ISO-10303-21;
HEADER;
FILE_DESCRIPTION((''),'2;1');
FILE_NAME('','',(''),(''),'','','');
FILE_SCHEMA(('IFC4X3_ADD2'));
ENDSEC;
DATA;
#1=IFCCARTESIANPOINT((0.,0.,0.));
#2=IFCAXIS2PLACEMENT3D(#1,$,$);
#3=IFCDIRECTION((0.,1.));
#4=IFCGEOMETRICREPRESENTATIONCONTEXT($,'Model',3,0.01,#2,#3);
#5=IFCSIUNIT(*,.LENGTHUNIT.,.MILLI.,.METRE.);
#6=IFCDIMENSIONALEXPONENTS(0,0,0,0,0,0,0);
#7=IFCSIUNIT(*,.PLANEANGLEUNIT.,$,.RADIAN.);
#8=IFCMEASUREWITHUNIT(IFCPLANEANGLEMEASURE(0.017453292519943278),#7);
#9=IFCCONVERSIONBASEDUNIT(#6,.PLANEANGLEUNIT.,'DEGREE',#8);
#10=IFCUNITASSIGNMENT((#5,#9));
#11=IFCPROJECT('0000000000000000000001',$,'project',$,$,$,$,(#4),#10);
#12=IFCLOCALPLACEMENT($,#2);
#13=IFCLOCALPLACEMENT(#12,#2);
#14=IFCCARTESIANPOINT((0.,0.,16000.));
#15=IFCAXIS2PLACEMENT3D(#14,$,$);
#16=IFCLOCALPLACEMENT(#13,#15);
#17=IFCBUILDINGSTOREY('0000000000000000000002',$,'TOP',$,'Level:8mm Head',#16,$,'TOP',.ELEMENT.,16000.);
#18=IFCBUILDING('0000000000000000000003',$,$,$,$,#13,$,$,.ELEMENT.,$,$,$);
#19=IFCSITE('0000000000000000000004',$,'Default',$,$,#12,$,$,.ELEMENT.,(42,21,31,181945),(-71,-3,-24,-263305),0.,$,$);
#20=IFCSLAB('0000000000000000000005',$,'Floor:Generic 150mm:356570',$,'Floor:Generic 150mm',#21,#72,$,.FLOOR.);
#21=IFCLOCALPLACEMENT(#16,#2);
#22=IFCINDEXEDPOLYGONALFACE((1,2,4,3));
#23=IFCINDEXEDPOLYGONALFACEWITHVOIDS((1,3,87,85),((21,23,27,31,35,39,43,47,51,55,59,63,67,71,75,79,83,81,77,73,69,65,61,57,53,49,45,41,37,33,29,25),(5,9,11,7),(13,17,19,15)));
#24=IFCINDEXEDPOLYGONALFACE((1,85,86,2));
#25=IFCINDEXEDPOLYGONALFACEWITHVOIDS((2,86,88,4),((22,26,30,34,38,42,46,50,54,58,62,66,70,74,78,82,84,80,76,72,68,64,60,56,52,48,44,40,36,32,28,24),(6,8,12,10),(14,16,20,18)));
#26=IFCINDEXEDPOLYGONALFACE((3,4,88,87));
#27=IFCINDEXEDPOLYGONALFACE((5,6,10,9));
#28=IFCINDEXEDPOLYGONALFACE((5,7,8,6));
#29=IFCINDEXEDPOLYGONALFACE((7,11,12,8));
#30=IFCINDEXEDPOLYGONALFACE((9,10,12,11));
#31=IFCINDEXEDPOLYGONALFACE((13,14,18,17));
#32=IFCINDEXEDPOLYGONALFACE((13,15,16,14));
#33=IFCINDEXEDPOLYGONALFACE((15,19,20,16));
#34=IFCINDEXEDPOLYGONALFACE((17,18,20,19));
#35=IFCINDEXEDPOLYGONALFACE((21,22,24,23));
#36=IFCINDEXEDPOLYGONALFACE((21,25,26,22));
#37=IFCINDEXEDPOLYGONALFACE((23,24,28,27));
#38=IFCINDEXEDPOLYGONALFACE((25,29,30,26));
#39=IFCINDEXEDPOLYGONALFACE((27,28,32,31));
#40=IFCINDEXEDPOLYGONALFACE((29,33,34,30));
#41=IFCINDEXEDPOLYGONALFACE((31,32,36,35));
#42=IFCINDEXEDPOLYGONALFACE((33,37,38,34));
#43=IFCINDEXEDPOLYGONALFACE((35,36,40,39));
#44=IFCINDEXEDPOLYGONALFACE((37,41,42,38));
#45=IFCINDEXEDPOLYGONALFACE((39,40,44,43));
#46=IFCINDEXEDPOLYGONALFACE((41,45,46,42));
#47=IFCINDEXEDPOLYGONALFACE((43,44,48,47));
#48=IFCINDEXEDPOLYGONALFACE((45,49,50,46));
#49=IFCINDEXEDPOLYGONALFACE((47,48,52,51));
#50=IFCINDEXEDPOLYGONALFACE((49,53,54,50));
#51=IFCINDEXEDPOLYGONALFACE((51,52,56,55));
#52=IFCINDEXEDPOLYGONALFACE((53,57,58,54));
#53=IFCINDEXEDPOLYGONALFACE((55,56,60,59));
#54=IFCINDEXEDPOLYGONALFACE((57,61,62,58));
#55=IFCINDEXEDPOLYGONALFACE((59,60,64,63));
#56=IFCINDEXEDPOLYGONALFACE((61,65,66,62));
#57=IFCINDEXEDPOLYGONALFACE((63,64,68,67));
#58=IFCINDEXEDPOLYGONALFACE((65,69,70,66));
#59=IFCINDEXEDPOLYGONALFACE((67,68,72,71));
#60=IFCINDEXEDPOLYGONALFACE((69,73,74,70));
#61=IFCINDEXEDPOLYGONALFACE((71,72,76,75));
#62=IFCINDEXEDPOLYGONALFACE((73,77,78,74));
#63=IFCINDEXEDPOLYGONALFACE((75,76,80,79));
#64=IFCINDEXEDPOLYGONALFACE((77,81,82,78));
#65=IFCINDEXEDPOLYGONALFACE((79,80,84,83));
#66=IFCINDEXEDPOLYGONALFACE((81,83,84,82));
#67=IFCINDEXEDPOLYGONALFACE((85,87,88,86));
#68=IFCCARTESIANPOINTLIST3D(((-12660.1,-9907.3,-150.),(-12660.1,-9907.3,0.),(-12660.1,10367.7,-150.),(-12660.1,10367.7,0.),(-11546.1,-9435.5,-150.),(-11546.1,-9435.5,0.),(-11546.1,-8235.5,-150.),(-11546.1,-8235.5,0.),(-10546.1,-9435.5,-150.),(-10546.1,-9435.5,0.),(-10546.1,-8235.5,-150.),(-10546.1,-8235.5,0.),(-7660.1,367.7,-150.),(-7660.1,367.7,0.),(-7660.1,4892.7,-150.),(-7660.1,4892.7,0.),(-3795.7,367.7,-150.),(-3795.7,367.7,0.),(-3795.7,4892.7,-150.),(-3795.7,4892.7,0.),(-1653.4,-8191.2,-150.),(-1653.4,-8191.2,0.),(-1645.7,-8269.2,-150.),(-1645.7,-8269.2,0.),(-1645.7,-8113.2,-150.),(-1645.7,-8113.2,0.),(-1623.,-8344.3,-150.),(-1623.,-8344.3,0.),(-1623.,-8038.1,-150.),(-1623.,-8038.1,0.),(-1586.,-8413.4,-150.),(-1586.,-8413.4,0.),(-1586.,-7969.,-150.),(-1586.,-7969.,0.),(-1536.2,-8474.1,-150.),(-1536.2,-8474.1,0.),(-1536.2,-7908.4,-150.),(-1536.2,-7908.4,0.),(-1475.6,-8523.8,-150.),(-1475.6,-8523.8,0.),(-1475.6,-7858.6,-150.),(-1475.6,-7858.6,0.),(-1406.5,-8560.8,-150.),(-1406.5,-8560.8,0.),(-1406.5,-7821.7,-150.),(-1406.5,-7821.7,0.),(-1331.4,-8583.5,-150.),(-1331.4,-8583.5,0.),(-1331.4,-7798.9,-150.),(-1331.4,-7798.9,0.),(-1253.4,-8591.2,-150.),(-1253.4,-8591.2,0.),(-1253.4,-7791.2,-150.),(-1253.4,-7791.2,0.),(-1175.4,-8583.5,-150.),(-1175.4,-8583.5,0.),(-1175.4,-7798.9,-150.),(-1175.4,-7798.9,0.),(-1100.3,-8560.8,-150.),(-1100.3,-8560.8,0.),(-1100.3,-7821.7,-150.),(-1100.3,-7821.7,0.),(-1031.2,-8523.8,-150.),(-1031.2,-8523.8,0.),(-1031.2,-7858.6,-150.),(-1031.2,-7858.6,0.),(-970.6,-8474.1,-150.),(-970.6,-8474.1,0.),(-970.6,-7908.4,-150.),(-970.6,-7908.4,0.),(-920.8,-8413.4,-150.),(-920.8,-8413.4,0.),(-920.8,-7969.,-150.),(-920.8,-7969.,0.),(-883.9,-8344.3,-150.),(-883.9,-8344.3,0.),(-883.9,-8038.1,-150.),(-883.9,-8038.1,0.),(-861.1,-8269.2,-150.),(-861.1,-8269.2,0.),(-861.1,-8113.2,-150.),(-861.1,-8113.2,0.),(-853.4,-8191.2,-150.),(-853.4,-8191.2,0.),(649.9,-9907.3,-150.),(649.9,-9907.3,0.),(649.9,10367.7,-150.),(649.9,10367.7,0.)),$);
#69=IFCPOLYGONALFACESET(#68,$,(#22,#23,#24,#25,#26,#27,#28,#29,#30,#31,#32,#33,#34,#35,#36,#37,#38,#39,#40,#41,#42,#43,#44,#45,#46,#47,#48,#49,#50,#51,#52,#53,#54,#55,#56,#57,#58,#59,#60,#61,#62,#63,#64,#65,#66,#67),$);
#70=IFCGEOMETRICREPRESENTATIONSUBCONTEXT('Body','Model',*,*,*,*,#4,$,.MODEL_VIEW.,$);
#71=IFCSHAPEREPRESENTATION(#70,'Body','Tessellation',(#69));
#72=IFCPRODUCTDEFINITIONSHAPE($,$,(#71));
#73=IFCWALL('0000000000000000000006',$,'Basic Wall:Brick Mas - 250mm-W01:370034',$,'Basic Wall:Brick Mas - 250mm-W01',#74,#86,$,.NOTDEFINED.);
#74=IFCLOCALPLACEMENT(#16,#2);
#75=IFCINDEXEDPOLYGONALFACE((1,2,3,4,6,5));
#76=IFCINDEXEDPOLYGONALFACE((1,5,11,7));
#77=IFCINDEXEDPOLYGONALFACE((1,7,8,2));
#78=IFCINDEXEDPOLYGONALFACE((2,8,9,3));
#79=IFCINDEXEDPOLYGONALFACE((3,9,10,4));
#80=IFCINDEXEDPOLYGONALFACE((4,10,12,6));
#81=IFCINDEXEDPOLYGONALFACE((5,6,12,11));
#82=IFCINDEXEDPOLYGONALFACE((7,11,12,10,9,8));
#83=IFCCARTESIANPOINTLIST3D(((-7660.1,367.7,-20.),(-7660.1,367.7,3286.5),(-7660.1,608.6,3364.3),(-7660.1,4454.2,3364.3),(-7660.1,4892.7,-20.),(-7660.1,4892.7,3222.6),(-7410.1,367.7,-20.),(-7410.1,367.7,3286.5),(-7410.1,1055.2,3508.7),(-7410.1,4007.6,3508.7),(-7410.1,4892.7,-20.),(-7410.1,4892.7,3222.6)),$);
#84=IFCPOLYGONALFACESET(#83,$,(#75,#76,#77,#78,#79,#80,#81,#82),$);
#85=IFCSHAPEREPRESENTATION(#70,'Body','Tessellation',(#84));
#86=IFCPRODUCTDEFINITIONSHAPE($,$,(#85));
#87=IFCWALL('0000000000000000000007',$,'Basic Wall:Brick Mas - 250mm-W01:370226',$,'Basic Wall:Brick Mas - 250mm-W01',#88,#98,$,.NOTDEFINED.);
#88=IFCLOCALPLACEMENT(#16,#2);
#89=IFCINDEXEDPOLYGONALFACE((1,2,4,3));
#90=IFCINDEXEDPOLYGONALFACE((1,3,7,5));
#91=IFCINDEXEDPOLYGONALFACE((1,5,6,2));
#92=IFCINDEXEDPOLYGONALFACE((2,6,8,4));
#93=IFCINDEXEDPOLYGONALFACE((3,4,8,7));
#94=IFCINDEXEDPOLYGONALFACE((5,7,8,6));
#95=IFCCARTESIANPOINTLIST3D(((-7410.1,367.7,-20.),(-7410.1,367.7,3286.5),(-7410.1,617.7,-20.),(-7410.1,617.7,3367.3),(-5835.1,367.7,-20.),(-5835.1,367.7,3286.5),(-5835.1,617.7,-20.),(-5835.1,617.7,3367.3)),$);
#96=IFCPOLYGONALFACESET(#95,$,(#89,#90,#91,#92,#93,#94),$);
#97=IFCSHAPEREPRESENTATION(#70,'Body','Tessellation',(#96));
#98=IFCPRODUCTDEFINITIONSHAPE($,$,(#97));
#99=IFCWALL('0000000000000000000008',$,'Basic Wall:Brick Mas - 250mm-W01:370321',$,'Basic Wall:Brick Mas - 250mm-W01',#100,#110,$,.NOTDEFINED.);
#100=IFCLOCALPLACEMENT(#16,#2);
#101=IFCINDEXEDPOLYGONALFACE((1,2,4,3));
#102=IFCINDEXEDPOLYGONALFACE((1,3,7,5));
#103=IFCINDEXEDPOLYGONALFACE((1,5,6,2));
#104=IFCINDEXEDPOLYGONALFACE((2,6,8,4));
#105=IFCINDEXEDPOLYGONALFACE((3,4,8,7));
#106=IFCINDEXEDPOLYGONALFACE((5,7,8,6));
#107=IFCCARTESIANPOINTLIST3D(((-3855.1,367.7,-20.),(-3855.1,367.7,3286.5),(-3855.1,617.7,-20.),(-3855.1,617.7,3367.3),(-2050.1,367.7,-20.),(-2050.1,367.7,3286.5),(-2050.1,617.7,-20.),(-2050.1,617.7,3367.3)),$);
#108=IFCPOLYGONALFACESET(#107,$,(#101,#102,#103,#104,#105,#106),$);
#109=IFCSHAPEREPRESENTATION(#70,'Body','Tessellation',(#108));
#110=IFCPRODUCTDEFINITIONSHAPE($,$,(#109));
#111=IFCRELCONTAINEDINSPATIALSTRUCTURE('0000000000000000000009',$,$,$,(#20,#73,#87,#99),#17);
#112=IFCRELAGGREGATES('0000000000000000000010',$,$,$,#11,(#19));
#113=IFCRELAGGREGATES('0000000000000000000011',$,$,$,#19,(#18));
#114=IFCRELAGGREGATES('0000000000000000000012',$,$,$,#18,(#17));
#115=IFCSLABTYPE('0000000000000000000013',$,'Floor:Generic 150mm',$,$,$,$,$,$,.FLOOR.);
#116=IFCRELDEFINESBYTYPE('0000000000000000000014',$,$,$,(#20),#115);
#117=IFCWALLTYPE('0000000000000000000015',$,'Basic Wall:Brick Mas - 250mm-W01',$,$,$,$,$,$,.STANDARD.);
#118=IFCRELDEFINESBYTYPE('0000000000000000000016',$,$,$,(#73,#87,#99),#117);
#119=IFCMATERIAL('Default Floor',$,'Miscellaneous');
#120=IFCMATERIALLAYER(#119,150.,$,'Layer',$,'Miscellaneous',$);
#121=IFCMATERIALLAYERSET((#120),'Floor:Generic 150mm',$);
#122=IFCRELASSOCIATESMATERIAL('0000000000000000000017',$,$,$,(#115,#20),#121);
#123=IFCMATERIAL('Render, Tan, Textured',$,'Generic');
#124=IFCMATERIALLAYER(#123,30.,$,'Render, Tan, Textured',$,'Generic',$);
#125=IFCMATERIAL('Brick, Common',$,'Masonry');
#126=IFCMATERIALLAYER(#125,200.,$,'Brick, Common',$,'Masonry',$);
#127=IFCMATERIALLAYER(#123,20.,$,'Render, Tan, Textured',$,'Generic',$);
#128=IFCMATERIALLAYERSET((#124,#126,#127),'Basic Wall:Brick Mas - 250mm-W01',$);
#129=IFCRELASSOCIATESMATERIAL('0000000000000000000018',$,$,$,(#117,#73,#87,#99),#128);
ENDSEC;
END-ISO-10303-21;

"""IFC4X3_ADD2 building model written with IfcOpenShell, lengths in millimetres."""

from ifc_helpers import new_model, entity, si_unit, converted_unit, direction, frame, frame_2d, origin, place, context, subcontext, project, spatial, polyline, rectangle, circle, extrude, clip, bounded_halfspace, material, layer, layer_set, layer_usage, type_object, element, save


model = new_model("IFC4X3_ADD2")

# Units and contexts
model_context = context("Model", 3, precision=0.01, world=origin(), true_north=direction((0.0, 1.0)))
body_context = subcontext(model_context, "Body", "Model", "MODEL_VIEW")
ifc_project = project(units=[si_unit("LENGTHUNIT", "METRE", prefix="MILLI"), converted_unit("PLANEANGLEUNIT", "DEGREE", entity("IfcPlaneAngleMeasure", 0.017453292519943278), si_unit("PLANEANGLEUNIT", "RADIAN"), dimensions=[0, 0, 0, 0, 0, 0, 0])], contexts=[model_context])

# Site, building, storey
site_placement = place(None, origin())
site = spatial("IfcSite", under=ifc_project, at=site_placement, Name="Default", CompositionType="ELEMENT", RefLatitude=(42, 21, 31, 181945), RefLongitude=(-71, -3, -24, -263305), RefElevation=0.0)
building_placement = place(site_placement, origin())
building = spatial("IfcBuilding", under=site, at=building_placement, CompositionType="ELEMENT")
storey_placement = place(building_placement, frame((0.0, 0.0, 16000.0)))
storey = spatial("IfcBuildingStorey", under=building, at=storey_placement, Name="TOP", ObjectType="Level:8mm Head", LongName="TOP", CompositionType="ELEMENT", Elevation=16000.0)

# Slab, openings
ifc_material_1 = material(Name="Default Floor", Category="Miscellaneous")
ifc_layer_1 = layer(ifc_material_1, 150.0, Name="Layer", Category="Miscellaneous")
ifc_layer_set_1 = layer_set([ifc_layer_1], Name="Floor:Generic 150mm")
ifc_layer_usage = layer_usage(ifc_layer_set_1, "AXIS3", "POSITIVE", 0.0)
slab_type = type_object("IfcSlabType", Name="Floor:Generic 150mm", PredefinedType="FLOOR", material=ifc_layer_set_1)
slab_placement = place(storey_placement, frame((-12660.1, -9907.3, -150.0)))
slab = element("IfcSlab", 1, at=slab_placement, inside=storey, type_object=slab_type, material=ifc_layer_usage, Name="Floor:Generic 150mm:356570", ObjectType="Floor:Generic 150mm", PredefinedType="FLOOR", context=body_context, shape_type="SweptSolid", body=[
    extrude(rectangle(XDim=20275.0, YDim=13310.0, at=frame_2d((0.0, 0.0), x_axis=(0.0, -1.0))), frame((6655.0, 10137.5, 150.0), z_axis=(0.0, 0.0, -1.0), x_axis=(-1.0, 0.0, 0.0)), (0.0, 0.0, 1.0), 150.0),
])
opening_1_placement = place(slab_placement, origin())
element("IfcOpeningElement", 2, at=opening_1_placement, cuts=slab, PredefinedType="OPENING", context=body_context, shape_type="SweptSolid", body=[
    extrude(circle(Radius=400.0, at=frame_2d((0.0, 0.0), x_axis=(1.0, 0.0))), frame((11406.7, 1716.1, 0.0)), (0.0, 0.0, 1.0), 150.0),
])
opening_2_placement = place(slab_placement, origin())
element("IfcOpeningElement", 3, at=opening_2_placement, cuts=slab, PredefinedType="OPENING", context=body_context, shape_type="SweptSolid", body=[
    extrude(rectangle(XDim=3864.4, YDim=4525.0, at=frame_2d((0.0, 0.0), x_axis=(1.0, 0.0))), frame((6932.2, 12537.5, 150.0), z_axis=(0.0, 0.0, -1.0), x_axis=(-1.0, 0.0, 0.0)), (0.0, 0.0, 1.0), 150.0),
])
opening_3_placement = place(slab_placement, origin())
element("IfcOpeningElement", 4, at=opening_3_placement, cuts=slab, PredefinedType="OPENING", context=body_context, shape_type="SweptSolid", body=[
    extrude(rectangle(XDim=1000.0, YDim=1200.0, at=frame_2d((0.0, 0.0), x_axis=(1.0, 0.0))), frame((1613.9, 1071.8, 150.0), z_axis=(0.0, 0.0, -1.0), x_axis=(-1.0, 0.0, 0.0)), (0.0, 0.0, 1.0), 150.0),
])

# Walls
ifc_material_2 = material(Name="Render, Tan, Textured", Category="Generic")
ifc_layer_2 = layer(ifc_material_2, 30.0, Name="Render, Tan, Textured", Category="Generic")
ifc_material_3 = material(Name="Brick, Common", Category="Masonry")
ifc_layer_3 = layer(ifc_material_3, 200.0, Name="Brick, Common", Category="Masonry")
ifc_layer_4 = layer(ifc_material_2, 20.0, Name="Render, Tan, Textured", Category="Generic")
ifc_layer_set_2 = layer_set([ifc_layer_2, ifc_layer_3, ifc_layer_4], Name="Basic Wall:Brick Mas - 250mm-W01")
wall_type = type_object("IfcWallType", Name="Basic Wall:Brick Mas - 250mm-W01", PredefinedType="STANDARD", material=ifc_layer_set_2)
wall_1_placement = place(storey_placement, frame((-7535.1, 367.7, -20.0), z_axis=(0.0, 0.0, 1.0), x_axis=(0.0, 1.0, 0.0)))
element("IfcWall", 5, at=wall_1_placement, inside=storey, type_object=wall_type, material=ifc_layer_set_2, Name="Basic Wall:Brick Mas - 250mm-W01:370034", ObjectType="Basic Wall:Brick Mas - 250mm-W01", PredefinedType="NOTDEFINED", context=body_context, shape_type="Clipping", body=[
    clip(clip(clip(extrude(rectangle(XDim=4525.0, YDim=250.0, at=frame_2d((2262.5, 0.0), x_axis=(-1.0, 0.0))), origin(), (0.0, 0.0, 1.0), 3528.7), bounded_halfspace(frame((3639.9, -125.0, 3528.7), z_axis=(0.307548, 0.0, 0.951533), x_axis=(0.0, 1.0, 0.0)), False, frame((3639.9, -125.0, 3528.7)), polyline([(0.0, 0.0), (885.1, 0.0), (885.1, 250.0), (446.6, 250.0), (0.0, 0.0)]))), bounded_halfspace(frame((687.5, -125.0, 3528.7), z_axis=(0.0, 0.5, 0.866025), x_axis=(-1.0, 0.0, 0.0)), False, frame((687.5, -125.0, 3528.7)), polyline([(0.0, 0.0), (2952.4, 0.0), (3399.0, 250.0), (-446.6, 250.0), (0.0, 0.0)]))), bounded_halfspace(frame((0.0, -125.0, 3306.5), z_axis=(-0.307548, 0.0, 0.951533), x_axis=(0.0, -1.0, 0.0)), False, frame((0.0, -125.0, 3306.5)), polyline([(0.0, 0.0), (250.0, 0.0), (687.5, 0.0), (240.9, 250.0), (0.0, 250.0), (0.0, 0.0)]))),
])
wall_2_placement = place(storey_placement, frame((-7410.1, 492.7, -20.0)))
element("IfcWall", 6, at=wall_2_placement, inside=storey, type_object=wall_type, material=ifc_layer_set_2, Name="Basic Wall:Brick Mas - 250mm-W01:370226", ObjectType="Basic Wall:Brick Mas - 250mm-W01", PredefinedType="NOTDEFINED", context=body_context, shape_type="Clipping", body=[
    clip(extrude(rectangle(XDim=1575.0, YDim=250.0, at=frame_2d((787.5, 0.0), x_axis=(-1.0, 0.0))), origin(), (0.0, 0.0, 1.0), 3387.3), bounded_halfspace(frame((0.0, -125.0, 3306.5), z_axis=(0.0, -0.307548, 0.951533), x_axis=(1.0, 0.0, 0.0)), False, frame((0.0, -125.0, 3306.5)), polyline([(0.0, 0.0), (1575.0, 0.0), (1575.0, 250.0), (0.0, 250.0), (0.0, 0.0)]))),
])
wall_3_placement = place(storey_placement, frame((-3855.1, 492.7, -20.0)))
element("IfcWall", 7, at=wall_3_placement, inside=storey, type_object=wall_type, material=ifc_layer_set_2, Name="Basic Wall:Brick Mas - 250mm-W01:370321", ObjectType="Basic Wall:Brick Mas - 250mm-W01", PredefinedType="NOTDEFINED", context=body_context, shape_type="Clipping", body=[
    clip(extrude(rectangle(XDim=1805.0, YDim=250.0, at=frame_2d((902.5, 0.0), x_axis=(-1.0, 0.0))), origin(), (0.0, 0.0, 1.0), 3387.3), bounded_halfspace(frame((0.0, -125.0, 3306.5), z_axis=(0.0, -0.307548, 0.951533), x_axis=(1.0, 0.0, 0.0)), False, frame((0.0, -125.0, 3306.5)), polyline([(0.0, 0.0), (1805.0, 0.0), (1805.0, 250.0), (0.0, 250.0), (0.0, 0.0)]))),
])

save(model, "model.ifc")
